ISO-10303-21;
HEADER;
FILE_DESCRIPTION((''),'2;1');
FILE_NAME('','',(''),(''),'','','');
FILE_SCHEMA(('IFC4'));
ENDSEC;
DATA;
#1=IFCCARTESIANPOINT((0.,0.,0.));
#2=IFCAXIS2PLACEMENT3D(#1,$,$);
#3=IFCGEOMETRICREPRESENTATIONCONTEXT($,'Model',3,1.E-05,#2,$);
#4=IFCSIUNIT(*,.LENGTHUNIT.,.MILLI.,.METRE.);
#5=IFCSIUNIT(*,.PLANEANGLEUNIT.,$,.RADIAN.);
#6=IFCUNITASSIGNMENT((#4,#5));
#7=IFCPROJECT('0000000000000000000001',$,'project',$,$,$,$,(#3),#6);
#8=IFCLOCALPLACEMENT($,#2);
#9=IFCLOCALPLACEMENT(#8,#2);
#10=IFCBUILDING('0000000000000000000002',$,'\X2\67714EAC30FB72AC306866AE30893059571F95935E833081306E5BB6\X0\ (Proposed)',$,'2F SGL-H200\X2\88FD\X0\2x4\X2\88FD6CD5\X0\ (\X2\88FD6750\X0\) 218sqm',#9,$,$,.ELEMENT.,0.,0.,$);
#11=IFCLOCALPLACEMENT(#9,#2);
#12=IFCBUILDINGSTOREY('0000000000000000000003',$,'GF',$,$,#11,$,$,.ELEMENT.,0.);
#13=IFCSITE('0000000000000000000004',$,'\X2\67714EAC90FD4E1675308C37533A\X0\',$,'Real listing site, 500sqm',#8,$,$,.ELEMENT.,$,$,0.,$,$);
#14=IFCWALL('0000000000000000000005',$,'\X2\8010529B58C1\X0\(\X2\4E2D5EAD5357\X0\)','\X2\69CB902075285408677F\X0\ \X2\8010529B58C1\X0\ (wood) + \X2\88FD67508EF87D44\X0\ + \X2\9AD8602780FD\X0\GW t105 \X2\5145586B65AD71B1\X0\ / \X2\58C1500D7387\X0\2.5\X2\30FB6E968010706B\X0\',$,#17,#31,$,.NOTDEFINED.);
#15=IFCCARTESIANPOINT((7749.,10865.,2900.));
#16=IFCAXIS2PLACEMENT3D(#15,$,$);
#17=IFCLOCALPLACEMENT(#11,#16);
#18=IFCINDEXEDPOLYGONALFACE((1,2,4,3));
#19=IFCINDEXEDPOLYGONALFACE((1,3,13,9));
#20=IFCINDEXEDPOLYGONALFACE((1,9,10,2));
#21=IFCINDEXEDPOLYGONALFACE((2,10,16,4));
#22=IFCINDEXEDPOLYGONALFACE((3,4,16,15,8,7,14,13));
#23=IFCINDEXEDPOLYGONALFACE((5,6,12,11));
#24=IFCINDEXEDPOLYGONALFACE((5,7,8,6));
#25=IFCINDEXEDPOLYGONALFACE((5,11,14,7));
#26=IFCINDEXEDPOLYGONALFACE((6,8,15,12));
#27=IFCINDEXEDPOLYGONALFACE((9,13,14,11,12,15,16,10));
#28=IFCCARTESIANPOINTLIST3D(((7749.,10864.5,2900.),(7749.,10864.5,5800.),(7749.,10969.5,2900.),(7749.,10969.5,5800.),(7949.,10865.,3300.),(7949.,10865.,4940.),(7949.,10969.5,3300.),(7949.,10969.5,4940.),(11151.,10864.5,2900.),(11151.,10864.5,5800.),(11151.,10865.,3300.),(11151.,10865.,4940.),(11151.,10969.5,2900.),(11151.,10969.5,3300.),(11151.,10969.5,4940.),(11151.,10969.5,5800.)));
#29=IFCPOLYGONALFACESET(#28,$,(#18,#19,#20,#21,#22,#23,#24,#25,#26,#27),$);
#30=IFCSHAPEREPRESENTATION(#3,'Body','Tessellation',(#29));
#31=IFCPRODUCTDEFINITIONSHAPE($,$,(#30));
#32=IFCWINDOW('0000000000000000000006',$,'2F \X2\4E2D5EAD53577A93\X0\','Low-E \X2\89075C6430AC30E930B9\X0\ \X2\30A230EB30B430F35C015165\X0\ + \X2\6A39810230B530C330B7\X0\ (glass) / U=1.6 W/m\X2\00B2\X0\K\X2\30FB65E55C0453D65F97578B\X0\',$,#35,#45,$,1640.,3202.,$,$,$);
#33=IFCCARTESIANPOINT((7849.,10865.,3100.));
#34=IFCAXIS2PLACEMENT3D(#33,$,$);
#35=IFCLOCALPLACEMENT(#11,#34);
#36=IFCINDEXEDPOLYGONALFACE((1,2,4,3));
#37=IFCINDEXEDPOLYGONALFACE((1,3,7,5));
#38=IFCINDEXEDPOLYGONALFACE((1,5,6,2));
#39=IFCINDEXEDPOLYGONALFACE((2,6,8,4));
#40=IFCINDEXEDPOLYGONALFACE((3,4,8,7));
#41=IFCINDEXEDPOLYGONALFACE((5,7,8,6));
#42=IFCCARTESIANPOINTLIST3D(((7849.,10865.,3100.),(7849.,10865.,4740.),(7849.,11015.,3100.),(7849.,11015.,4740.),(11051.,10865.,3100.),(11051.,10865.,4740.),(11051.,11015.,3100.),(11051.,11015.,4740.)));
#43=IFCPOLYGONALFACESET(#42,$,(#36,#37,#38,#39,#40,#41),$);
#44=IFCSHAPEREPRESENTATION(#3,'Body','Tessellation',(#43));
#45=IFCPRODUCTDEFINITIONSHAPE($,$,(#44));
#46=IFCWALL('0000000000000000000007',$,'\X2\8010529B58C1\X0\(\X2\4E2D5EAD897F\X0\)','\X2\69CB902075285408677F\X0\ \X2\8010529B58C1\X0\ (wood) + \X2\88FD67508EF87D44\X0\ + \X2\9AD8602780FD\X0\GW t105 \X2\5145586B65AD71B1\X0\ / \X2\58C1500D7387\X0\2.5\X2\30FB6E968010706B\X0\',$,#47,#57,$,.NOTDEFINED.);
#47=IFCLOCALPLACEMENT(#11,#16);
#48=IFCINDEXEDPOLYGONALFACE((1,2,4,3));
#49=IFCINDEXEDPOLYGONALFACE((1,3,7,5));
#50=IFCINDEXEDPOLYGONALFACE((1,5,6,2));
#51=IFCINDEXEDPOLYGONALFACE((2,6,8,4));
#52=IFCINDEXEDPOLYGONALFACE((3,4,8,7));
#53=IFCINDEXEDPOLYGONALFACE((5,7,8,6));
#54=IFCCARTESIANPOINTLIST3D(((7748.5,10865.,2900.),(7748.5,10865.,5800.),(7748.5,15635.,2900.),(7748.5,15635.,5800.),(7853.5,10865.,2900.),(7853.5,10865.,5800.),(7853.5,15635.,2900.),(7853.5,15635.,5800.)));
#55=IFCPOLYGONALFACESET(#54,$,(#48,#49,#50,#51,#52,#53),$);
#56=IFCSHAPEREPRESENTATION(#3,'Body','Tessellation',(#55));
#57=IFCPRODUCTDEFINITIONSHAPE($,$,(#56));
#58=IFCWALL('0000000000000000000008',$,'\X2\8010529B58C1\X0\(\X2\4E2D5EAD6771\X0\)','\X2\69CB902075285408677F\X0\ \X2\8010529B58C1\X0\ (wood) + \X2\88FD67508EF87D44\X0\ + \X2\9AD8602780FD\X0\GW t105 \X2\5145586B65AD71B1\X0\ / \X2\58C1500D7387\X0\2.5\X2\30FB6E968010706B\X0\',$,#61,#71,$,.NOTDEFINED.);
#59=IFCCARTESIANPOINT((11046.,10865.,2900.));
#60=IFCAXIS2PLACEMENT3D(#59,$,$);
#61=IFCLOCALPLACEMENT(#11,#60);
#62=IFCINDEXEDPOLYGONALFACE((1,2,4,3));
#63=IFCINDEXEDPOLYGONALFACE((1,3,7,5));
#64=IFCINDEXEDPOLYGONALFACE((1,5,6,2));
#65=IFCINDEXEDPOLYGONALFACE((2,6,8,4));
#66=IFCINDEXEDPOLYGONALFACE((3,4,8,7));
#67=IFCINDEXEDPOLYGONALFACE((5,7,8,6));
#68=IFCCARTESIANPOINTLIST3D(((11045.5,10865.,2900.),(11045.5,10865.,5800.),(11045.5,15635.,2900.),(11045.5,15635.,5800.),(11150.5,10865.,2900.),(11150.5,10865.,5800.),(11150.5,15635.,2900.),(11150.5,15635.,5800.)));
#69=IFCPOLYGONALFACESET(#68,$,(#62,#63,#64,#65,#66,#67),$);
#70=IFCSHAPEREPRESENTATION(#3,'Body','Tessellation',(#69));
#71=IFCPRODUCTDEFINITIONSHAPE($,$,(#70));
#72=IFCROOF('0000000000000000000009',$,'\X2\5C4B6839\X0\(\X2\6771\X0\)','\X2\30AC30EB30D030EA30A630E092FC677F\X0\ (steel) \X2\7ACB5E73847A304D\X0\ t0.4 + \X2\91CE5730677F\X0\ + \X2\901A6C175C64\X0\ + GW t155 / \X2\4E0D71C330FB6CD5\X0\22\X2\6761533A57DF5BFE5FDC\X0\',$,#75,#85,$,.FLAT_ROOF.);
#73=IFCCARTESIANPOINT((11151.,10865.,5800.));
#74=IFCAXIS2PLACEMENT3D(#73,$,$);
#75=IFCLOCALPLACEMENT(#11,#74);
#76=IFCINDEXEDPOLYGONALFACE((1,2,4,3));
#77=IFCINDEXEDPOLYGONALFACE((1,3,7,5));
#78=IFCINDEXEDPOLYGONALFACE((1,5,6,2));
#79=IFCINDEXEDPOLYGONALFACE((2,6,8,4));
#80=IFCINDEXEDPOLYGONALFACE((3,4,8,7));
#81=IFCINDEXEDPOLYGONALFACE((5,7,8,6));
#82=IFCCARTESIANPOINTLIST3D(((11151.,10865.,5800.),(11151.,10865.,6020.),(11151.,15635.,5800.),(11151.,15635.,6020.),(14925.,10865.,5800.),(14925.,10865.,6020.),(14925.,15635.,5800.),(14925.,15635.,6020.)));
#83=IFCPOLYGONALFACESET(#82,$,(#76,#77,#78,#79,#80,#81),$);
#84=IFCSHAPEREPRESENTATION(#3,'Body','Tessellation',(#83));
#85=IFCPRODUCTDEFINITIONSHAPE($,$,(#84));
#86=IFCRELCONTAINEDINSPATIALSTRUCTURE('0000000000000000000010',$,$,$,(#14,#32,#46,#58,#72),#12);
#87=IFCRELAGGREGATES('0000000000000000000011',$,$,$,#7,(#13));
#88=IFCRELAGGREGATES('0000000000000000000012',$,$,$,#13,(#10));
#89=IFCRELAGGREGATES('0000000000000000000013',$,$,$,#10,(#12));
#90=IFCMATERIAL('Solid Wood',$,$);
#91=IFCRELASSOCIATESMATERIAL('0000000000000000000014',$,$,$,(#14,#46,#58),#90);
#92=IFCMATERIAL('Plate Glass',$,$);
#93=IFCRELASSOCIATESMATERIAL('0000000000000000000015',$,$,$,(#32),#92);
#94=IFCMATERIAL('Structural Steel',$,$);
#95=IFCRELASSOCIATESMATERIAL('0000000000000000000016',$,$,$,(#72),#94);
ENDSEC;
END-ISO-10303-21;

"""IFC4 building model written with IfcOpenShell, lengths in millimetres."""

from ifc_helpers import new_model, si_unit, frame, frame_2d, origin, place, context, project, spatial, rectangle, extrude, material, element, fill, save


model = new_model("IFC4")

# Units and contexts
model_context = context("Model", 3, precision=1e-05, world=origin())
ifc_project = project(units=[si_unit("LENGTHUNIT", "METRE", prefix="MILLI"), si_unit("PLANEANGLEUNIT", "RADIAN")], contexts=[model_context])

# Site, building, storey
site_placement = place(None, origin())
site = spatial("IfcSite", under=ifc_project, at=site_placement, Name="東京都世田谷区", ObjectType="Real listing site, 500sqm", CompositionType="ELEMENT", RefElevation=0.0)
building_placement = place(site_placement, origin())
building = spatial("IfcBuilding", under=site, at=building_placement, Name="東京・犬と暮らす土間広めの家 (Proposed)", ObjectType="2F SGL-H200製2x4製法 (製材) 218sqm", CompositionType="ELEMENT", ElevationOfRefHeight=0.0, ElevationOfTerrain=0.0)
storey_placement = place(building_placement, origin())
storey = spatial("IfcBuildingStorey", under=building, at=storey_placement, Name="GF", CompositionType="ELEMENT", Elevation=0.0)

# Shared definitions
ifc_material_1 = material(Name="Solid Wood")

# Wall, opening, window
wall_1_placement = place(storey_placement, frame((7749.0, 10865.0, 2900.0)))
wall_1 = element("IfcWall", 1, at=wall_1_placement, inside=storey, material=ifc_material_1, Name="耐力壁(中庭南)", Description="構造用合板 耐力壁 (wood) + 製材軸組 + 高性能GW t105 充填断熱 / 壁倍率2.5・準耐火", PredefinedType="NOTDEFINED", context=model_context, shape_type="SweptSolid", body=[
    extrude(rectangle(XDim=3402.0, YDim=105.0, at=frame_2d((1701.0, 52.0))), frame((7749.0, 10865.0, 2900.0)), (0.0, 0.0, 1.0), 2900.0),
])
opening_placement = place(storey_placement, frame((7849.0, 10865.0, 3100.0)))
opening = element("IfcOpeningElement", 2, at=opening_placement, cuts=wall_1, PredefinedType="NOTDEFINED", context=model_context, shape_type="SweptSolid", body=[
    extrude(rectangle(XDim=3202.0, YDim=150.0, at=frame_2d((1601.0, 75.0))), frame((7849.0, 10865.0, 3100.0)), (0.0, 0.0, 1.0), 1640.0),
])
ifc_material_2 = material(Name="Plate Glass")
window_placement = place(storey_placement, frame((7849.0, 10865.0, 3100.0)))
window = element("IfcWindow", 3, at=window_placement, inside=storey, material=ifc_material_2, Name="2F 中庭南窓", Description="Low-E 複層ガラス アルゴン封入 + 樹脂サッシ (glass) / U=1.6 W/m²K・日射取得型", OverallHeight=1640.0, OverallWidth=3202.0, context=model_context, shape_type="SweptSolid", body=[
    extrude(rectangle(XDim=3202.0, YDim=150.0, at=frame_2d((1601.0, 75.0))), frame((7849.0, 10865.0, 3100.0)), (0.0, 0.0, 1.0), 1640.0),
])
fill(opening, window)

# Walls
wall_2_placement = place(storey_placement, frame((7749.0, 10865.0, 2900.0)))
element("IfcWall", 4, at=wall_2_placement, inside=storey, material=ifc_material_1, Name="耐力壁(中庭西)", Description="構造用合板 耐力壁 (wood) + 製材軸組 + 高性能GW t105 充填断熱 / 壁倍率2.5・準耐火", PredefinedType="NOTDEFINED", context=model_context, shape_type="SweptSolid", body=[
    extrude(rectangle(XDim=105.0, YDim=4770.0, at=frame_2d((52.0, 2385.0))), frame((7749.0, 10865.0, 2900.0)), (0.0, 0.0, 1.0), 2900.0),
])
wall_3_placement = place(storey_placement, frame((11046.0, 10865.0, 2900.0)))
element("IfcWall", 5, at=wall_3_placement, inside=storey, material=ifc_material_1, Name="耐力壁(中庭東)", Description="構造用合板 耐力壁 (wood) + 製材軸組 + 高性能GW t105 充填断熱 / 壁倍率2.5・準耐火", PredefinedType="NOTDEFINED", context=model_context, shape_type="SweptSolid", body=[
    extrude(rectangle(XDim=105.0, YDim=4770.0, at=frame_2d((52.0, 2385.0))), frame((11046.0, 10865.0, 2900.0)), (0.0, 0.0, 1.0), 2900.0),
])

# Roof
ifc_material_3 = material(Name="Structural Steel")
for number, where, name in (
    (6, (11151.0, 10865.0, 5800.0), "屋根(東)"),
):
    element("IfcRoof", number, at=place(storey_placement, frame(where)), inside=storey, material=ifc_material_3, Name=name, Description="ガルバリウム鋼板 (steel) 立平葺き t0.4 + 野地板 + 通気層 + GW t155 / 不燃・法22条区域対応", PredefinedType="FLAT_ROOF", context=model_context, shape_type="SweptSolid", body=[
        extrude(rectangle(XDim=3774.0, YDim=4770.0, at=frame_2d((1887.0, 2385.0))), frame((11151.0, 10865.0, 5800.0)), (0.0, 0.0, 1.0), 220.0),
    ])

save(model, "model.ifc")
